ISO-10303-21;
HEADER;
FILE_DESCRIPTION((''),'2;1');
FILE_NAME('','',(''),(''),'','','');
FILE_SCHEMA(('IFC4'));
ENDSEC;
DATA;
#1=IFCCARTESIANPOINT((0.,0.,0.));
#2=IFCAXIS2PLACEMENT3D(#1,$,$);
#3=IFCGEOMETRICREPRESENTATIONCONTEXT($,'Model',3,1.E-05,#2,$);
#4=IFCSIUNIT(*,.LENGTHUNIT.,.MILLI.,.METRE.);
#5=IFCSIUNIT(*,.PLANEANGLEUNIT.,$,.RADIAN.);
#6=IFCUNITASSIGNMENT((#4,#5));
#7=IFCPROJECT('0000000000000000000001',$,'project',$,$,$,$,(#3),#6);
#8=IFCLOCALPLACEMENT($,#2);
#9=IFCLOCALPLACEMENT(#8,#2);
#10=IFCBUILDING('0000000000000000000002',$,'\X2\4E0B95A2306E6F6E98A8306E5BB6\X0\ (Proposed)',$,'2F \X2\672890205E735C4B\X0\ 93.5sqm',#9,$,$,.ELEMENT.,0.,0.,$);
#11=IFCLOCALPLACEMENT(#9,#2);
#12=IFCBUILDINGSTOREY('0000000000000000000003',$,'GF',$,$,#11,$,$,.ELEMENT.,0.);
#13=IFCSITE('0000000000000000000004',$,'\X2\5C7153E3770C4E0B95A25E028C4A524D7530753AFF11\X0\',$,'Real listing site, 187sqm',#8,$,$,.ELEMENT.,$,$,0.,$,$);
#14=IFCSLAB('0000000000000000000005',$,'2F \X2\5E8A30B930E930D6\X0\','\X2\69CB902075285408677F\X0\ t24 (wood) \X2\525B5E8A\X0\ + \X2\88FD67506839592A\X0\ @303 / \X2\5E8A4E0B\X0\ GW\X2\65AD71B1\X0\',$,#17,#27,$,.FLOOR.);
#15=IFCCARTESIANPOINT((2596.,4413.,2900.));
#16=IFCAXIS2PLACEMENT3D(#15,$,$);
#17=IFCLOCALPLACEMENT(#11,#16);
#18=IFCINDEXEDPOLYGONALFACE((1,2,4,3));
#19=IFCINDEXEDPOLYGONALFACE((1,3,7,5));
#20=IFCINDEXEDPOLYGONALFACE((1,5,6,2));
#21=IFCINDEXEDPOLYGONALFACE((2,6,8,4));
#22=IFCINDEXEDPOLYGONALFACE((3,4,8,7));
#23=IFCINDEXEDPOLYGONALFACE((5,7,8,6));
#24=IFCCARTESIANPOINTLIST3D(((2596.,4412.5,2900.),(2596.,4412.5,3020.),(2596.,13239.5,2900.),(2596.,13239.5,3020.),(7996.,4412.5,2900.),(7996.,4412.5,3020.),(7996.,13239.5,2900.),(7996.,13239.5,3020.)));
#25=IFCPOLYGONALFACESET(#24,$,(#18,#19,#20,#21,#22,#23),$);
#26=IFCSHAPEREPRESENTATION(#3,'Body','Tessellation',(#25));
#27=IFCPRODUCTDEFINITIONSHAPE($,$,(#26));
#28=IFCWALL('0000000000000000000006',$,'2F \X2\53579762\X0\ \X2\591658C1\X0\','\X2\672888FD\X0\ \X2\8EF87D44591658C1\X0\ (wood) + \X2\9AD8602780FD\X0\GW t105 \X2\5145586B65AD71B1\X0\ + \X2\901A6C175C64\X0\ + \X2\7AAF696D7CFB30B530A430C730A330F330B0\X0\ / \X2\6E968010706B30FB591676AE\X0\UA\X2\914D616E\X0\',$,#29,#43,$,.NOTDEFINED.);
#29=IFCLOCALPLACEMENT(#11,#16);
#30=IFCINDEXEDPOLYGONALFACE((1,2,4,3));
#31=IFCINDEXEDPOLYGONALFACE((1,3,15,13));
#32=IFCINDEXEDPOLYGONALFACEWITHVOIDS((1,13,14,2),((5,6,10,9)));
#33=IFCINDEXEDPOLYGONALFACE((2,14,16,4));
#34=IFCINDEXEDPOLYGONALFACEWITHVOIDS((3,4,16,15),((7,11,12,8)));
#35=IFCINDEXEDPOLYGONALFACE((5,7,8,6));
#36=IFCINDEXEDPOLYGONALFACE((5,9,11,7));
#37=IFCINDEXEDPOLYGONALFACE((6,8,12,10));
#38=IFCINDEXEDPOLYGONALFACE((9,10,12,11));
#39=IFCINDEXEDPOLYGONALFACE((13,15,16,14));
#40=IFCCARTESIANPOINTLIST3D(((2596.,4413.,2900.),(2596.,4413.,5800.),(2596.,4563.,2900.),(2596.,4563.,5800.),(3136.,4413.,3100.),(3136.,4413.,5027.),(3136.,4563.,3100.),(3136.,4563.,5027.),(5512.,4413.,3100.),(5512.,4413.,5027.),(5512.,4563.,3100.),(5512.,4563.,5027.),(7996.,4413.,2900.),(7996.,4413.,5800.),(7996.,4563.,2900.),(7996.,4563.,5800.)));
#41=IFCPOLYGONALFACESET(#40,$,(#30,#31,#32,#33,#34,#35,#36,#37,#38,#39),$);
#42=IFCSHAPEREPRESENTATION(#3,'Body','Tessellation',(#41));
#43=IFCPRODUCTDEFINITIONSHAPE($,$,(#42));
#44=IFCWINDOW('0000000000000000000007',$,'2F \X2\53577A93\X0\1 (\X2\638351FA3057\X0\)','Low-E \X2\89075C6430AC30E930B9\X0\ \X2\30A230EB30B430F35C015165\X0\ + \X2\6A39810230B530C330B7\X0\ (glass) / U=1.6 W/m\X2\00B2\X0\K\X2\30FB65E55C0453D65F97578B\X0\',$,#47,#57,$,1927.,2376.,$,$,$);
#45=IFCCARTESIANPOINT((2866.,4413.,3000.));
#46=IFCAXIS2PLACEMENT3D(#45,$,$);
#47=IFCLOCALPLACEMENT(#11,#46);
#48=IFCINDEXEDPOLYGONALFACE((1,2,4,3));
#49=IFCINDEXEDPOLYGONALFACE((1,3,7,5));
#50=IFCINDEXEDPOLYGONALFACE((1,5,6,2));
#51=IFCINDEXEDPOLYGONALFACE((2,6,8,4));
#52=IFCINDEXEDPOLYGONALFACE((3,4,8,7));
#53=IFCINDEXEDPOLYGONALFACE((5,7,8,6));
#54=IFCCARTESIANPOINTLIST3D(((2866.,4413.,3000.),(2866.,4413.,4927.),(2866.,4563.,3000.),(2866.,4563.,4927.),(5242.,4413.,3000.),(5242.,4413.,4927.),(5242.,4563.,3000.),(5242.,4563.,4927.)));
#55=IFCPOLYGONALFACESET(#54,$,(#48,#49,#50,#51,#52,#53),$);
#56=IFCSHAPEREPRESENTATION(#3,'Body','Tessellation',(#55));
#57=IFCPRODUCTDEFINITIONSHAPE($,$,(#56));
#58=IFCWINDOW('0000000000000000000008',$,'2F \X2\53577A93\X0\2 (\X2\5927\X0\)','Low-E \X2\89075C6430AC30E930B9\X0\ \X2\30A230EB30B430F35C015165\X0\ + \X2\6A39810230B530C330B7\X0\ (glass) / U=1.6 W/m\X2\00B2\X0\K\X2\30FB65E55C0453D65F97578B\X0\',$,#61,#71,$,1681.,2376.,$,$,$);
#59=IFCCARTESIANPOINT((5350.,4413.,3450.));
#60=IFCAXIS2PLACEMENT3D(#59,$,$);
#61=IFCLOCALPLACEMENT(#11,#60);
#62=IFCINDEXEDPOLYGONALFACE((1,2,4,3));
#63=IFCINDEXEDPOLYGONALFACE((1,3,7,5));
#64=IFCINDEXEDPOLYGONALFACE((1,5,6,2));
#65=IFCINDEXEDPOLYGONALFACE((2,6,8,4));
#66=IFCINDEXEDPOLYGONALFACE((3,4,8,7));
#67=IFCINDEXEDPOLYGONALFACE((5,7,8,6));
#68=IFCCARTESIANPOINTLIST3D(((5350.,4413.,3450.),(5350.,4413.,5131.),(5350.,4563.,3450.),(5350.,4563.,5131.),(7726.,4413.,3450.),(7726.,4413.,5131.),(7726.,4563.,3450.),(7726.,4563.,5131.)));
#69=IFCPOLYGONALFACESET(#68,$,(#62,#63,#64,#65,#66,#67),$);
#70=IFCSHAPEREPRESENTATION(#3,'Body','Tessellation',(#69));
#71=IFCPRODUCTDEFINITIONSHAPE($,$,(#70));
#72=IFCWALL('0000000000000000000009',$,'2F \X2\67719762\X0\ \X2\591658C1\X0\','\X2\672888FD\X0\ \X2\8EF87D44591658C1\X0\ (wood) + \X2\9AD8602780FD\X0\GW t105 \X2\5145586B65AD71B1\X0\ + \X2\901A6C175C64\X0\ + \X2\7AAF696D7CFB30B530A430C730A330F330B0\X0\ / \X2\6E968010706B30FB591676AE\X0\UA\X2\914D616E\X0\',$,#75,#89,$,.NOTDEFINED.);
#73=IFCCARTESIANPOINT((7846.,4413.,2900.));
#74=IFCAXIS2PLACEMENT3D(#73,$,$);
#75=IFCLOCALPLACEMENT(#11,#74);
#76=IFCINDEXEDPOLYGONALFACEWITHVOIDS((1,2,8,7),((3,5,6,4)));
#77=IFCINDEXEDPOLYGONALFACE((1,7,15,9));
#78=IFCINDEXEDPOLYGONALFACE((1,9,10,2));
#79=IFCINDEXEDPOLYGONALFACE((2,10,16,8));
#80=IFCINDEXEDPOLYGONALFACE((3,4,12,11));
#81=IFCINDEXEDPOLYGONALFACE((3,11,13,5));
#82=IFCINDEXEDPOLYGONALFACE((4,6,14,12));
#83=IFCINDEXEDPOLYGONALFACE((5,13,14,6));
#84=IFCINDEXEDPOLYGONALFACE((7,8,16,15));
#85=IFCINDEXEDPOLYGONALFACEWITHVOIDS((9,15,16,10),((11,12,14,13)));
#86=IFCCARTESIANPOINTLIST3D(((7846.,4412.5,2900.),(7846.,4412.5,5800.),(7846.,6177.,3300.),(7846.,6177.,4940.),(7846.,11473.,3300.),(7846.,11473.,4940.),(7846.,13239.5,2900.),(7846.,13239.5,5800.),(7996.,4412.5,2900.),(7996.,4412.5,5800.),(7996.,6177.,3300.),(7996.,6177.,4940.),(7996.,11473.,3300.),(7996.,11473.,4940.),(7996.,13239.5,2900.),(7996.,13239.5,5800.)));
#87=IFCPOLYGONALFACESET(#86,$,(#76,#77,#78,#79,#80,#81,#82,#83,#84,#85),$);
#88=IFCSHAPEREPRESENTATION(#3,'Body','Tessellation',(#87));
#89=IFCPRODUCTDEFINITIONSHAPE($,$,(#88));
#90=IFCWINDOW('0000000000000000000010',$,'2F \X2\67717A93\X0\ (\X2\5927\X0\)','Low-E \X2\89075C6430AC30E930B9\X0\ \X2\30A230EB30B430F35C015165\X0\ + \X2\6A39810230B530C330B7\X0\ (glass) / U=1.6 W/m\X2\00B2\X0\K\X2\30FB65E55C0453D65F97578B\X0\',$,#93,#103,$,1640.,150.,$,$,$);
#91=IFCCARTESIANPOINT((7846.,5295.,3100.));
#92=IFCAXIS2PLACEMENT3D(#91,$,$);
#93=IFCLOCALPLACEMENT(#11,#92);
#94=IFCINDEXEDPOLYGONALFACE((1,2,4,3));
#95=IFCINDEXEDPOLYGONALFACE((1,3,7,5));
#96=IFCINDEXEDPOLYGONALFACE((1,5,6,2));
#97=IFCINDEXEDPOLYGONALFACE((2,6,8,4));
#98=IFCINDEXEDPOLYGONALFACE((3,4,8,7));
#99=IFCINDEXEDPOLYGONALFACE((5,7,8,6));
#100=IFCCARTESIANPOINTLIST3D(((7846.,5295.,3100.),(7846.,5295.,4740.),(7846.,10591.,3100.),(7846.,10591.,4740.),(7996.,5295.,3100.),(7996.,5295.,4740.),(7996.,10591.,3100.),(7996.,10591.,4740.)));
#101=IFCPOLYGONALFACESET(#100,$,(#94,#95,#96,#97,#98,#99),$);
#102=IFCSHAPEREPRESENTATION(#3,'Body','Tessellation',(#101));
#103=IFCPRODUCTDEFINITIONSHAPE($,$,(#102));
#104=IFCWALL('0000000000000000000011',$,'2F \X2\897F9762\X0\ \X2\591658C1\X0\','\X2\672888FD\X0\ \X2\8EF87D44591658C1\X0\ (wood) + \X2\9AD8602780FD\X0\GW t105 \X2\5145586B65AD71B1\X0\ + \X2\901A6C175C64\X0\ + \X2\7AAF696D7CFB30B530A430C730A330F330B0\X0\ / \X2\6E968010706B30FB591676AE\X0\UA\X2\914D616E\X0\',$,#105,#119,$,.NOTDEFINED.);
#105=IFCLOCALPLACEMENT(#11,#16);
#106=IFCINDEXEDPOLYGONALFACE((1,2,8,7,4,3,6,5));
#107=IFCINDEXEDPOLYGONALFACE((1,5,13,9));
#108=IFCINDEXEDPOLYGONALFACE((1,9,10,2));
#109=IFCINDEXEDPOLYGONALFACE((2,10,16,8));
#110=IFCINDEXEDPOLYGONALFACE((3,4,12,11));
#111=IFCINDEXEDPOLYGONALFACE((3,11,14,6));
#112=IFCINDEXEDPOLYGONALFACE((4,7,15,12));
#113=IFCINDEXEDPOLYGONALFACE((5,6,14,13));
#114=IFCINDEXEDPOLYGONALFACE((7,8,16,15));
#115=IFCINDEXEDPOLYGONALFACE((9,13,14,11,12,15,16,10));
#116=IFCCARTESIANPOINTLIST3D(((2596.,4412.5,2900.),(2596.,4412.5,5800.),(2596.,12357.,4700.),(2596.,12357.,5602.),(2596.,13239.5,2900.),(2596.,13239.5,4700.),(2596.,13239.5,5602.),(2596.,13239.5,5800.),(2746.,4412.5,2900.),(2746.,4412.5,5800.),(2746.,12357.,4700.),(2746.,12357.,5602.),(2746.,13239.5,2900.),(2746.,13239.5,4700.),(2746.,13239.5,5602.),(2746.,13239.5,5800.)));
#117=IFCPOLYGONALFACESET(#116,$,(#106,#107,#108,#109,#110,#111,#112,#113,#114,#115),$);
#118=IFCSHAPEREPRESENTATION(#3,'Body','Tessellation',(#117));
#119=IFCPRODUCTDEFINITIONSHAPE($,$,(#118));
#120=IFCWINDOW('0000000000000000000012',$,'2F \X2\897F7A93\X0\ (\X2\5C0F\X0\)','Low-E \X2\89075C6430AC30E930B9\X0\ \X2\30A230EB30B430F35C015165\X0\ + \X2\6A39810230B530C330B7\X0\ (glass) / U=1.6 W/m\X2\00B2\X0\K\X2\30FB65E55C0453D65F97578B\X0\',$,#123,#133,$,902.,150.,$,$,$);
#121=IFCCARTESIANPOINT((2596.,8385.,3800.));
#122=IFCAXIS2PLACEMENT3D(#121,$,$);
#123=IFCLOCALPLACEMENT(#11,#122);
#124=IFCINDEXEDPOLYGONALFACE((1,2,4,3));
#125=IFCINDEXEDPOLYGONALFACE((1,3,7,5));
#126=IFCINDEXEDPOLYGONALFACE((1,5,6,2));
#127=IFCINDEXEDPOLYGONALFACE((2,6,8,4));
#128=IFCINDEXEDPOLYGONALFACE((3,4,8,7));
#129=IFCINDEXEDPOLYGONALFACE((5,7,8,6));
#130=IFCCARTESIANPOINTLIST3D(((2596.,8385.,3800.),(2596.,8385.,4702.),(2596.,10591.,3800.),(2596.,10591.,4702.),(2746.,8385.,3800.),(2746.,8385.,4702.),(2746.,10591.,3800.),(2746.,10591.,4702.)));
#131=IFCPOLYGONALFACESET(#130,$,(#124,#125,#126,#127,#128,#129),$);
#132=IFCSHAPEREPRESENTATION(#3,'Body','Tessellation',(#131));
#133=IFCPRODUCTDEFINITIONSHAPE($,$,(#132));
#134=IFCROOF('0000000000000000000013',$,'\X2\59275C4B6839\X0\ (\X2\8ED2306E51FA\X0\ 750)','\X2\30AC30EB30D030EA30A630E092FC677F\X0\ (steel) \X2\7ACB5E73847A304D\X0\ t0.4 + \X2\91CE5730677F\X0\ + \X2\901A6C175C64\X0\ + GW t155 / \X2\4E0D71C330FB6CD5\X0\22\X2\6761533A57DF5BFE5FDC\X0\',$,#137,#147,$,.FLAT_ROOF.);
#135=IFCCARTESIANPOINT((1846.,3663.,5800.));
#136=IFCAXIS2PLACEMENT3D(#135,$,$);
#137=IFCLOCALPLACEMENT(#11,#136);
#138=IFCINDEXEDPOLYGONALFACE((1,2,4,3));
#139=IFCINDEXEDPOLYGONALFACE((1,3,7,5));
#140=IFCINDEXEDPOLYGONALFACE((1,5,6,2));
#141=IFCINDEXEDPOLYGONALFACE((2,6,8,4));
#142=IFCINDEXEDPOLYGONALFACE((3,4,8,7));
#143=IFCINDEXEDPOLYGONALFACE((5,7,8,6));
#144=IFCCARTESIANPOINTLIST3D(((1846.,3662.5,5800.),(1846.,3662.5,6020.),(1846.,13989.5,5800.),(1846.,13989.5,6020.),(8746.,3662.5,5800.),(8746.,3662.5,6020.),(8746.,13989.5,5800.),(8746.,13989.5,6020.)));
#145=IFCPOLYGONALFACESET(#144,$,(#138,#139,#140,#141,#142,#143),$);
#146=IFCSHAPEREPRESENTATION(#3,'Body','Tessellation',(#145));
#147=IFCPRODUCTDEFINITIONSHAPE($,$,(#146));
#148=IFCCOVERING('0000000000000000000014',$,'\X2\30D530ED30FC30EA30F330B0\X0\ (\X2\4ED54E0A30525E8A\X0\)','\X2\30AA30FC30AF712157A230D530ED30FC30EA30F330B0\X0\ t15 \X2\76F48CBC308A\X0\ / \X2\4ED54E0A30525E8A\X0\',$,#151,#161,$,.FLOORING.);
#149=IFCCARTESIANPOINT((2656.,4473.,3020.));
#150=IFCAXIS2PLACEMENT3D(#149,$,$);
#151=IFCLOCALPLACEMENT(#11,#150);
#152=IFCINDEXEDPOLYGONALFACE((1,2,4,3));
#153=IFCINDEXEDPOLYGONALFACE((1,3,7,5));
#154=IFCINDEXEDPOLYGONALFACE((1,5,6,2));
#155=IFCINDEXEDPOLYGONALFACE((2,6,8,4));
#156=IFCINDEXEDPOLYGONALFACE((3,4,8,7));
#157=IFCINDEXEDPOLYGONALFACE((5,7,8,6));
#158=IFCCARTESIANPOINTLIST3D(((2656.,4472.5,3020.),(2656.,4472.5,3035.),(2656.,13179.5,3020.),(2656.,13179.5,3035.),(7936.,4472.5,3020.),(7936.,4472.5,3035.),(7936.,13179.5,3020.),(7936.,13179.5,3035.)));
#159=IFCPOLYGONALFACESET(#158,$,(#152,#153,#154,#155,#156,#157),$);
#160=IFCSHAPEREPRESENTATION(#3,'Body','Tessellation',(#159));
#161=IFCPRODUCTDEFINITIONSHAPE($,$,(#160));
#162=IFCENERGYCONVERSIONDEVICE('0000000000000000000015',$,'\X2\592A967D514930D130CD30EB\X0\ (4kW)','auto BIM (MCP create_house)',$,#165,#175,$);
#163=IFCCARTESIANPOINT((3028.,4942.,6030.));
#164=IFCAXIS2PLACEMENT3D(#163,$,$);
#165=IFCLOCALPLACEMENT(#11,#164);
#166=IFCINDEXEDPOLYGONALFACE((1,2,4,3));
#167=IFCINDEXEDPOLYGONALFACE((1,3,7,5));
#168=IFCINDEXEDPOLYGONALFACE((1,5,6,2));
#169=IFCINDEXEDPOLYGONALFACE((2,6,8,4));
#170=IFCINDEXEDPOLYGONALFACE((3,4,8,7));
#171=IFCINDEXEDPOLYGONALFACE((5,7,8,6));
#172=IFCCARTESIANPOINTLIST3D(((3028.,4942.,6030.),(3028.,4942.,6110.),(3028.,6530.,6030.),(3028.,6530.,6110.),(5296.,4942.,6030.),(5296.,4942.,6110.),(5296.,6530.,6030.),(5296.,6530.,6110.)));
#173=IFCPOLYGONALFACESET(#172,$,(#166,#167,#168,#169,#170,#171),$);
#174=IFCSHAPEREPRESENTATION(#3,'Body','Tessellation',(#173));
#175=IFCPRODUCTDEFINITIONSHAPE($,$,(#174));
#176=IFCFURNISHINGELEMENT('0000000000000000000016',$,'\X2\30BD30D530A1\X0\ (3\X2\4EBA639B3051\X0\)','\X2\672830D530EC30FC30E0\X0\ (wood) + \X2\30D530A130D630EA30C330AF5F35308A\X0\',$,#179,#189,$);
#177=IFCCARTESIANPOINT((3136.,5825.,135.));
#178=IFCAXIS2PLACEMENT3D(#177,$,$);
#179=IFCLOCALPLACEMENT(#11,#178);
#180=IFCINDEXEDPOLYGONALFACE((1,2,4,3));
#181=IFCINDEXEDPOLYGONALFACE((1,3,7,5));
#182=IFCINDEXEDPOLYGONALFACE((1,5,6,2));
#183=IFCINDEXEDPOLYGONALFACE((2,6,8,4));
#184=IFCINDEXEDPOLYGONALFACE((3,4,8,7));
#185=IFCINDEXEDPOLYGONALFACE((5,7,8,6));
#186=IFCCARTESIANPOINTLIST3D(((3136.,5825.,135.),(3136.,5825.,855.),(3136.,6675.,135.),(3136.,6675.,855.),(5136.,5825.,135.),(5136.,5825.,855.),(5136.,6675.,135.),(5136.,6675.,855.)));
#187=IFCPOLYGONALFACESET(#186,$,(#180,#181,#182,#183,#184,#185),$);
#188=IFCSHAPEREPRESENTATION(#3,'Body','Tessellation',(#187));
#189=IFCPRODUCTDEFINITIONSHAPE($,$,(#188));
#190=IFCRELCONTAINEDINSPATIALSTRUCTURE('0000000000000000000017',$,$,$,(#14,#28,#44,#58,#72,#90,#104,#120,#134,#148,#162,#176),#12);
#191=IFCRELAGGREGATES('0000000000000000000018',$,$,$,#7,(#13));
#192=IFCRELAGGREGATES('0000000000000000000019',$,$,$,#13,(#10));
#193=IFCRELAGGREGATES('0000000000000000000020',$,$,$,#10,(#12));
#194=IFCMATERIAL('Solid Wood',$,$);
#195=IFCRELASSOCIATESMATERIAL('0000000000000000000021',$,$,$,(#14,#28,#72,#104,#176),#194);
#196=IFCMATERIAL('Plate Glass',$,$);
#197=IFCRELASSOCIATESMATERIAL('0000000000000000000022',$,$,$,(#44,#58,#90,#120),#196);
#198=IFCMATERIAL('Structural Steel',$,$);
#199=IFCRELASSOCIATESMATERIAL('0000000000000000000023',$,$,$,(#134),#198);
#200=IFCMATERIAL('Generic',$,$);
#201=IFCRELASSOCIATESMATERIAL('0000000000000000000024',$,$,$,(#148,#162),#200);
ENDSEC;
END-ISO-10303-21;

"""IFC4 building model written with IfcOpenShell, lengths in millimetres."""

from ifc_helpers import new_model, si_unit, frame, frame_2d, origin, place, context, project, spatial, rectangle, extrude, material, element, fill, save


model = new_model("IFC4")

# Units and contexts
model_context = context("Model", 3, precision=1e-05, world=origin())
ifc_project = project(units=[si_unit("LENGTHUNIT", "METRE", prefix="MILLI"), si_unit("PLANEANGLEUNIT", "RADIAN")], contexts=[model_context])

# Site, building, storey
site_placement = place(None, origin())
site = spatial("IfcSite", under=ifc_project, at=site_placement, Name="山口県下関市豊前田町１", ObjectType="Real listing site, 187sqm", CompositionType="ELEMENT", RefElevation=0.0)
building_placement = place(site_placement, origin())
building = spatial("IfcBuilding", under=site, at=building_placement, Name="下関の潮風の家 (Proposed)", ObjectType="2F 木造平屋 93.5sqm", CompositionType="ELEMENT", ElevationOfRefHeight=0.0, ElevationOfTerrain=0.0)
storey_placement = place(building_placement, origin())
storey = spatial("IfcBuildingStorey", under=building, at=storey_placement, Name="GF", CompositionType="ELEMENT", Elevation=0.0)

# Slab
ifc_material_1 = material(Name="Solid Wood")
slab_placement = place(storey_placement, frame((2596.0, 4413.0, 2900.0)))
element("IfcSlab", 1, at=slab_placement, inside=storey, material=ifc_material_1, Name="2F 床スラブ", Description="構造用合板 t24 (wood) 剛床 + 製材根太 @303 / 床下 GW断熱", PredefinedType="FLOOR", context=model_context, shape_type="SweptSolid", body=[
    extrude(rectangle(XDim=5400.0, YDim=8827.0, at=frame_2d((2700.0, 4413.0))), frame((2596.0, 4413.0, 2900.0)), (0.0, 0.0, 1.0), 120.0),
])

# Wall, openings, windows
wall_1_placement = place(storey_placement, frame((2596.0, 4413.0, 2900.0)))
wall_1 = element("IfcWall", 2, at=wall_1_placement, inside=storey, material=ifc_material_1, Name="2F 南面 外壁", Description="木製 軸組外壁 (wood) + 高性能GW t105 充填断熱 + 通気層 + 窯業系サイディング / 準耐火・外皮UA配慮", PredefinedType="NOTDEFINED", context=model_context, shape_type="SweptSolid", body=[
    extrude(rectangle(XDim=5400.0, YDim=150.0, at=frame_2d((2700.0, 75.0))), frame((2596.0, 4413.0, 2900.0)), (0.0, 0.0, 1.0), 2900.0),
])
opening_1_placement = place(storey_placement, frame((2866.0, 4413.0, 3000.0)))
opening_1 = element("IfcOpeningElement", 3, at=opening_1_placement, cuts=wall_1, PredefinedType="NOTDEFINED", context=model_context, shape_type="SweptSolid", body=[
    extrude(rectangle(XDim=2376.0, YDim=150.0, at=frame_2d((1188.0, 75.0))), frame((2866.0, 4413.0, 3000.0)), (0.0, 0.0, 1.0), 1927.0),
])
opening_2_placement = place(storey_placement, frame((5350.0, 4413.0, 3450.0)))
opening_2 = element("IfcOpeningElement", 4, at=opening_2_placement, cuts=wall_1, PredefinedType="NOTDEFINED", context=model_context, shape_type="SweptSolid", body=[
    extrude(rectangle(XDim=2376.0, YDim=150.0, at=frame_2d((1188.0, 75.0))), frame((5350.0, 4413.0, 3450.0)), (0.0, 0.0, 1.0), 1681.0),
])
ifc_material_2 = material(Name="Plate Glass")
window_1_placement = place(storey_placement, frame((2866.0, 4413.0, 3000.0)))
window_1 = element("IfcWindow", 5, at=window_1_placement, inside=storey, material=ifc_material_2, Name="2F 南窓1 (掃出し)", Description="Low-E 複層ガラス アルゴン封入 + 樹脂サッシ (glass) / U=1.6 W/m²K・日射取得型", OverallHeight=1927.0, OverallWidth=2376.0, context=model_context, shape_type="SweptSolid", body=[
    extrude(rectangle(XDim=2376.0, YDim=150.0, at=frame_2d((1188.0, 75.0))), frame((2866.0, 4413.0, 3000.0)), (0.0, 0.0, 1.0), 1927.0),
])
fill(opening_1, window_1)
window_2_placement = place(storey_placement, frame((5350.0, 4413.0, 3450.0)))
window_2 = element("IfcWindow", 6, at=window_2_placement, inside=storey, material=ifc_material_2, Name="2F 南窓2 (大)", Description="Low-E 複層ガラス アルゴン封入 + 樹脂サッシ (glass) / U=1.6 W/m²K・日射取得型", OverallHeight=1681.0, OverallWidth=2376.0, context=model_context, shape_type="SweptSolid", body=[
    extrude(rectangle(XDim=2376.0, YDim=150.0, at=frame_2d((1188.0, 75.0))), frame((5350.0, 4413.0, 3450.0)), (0.0, 0.0, 1.0), 1681.0),
])
fill(opening_2, window_2)

# Walls, openings, windows
wall_2_placement = place(storey_placement, frame((7846.0, 4413.0, 2900.0)))
wall_2 = element("IfcWall", 7, at=wall_2_placement, inside=storey, material=ifc_material_1, Name="2F 東面 外壁", Description="木製 軸組外壁 (wood) + 高性能GW t105 充填断熱 + 通気層 + 窯業系サイディング / 準耐火・外皮UA配慮", PredefinedType="NOTDEFINED", context=model_context, shape_type="SweptSolid", body=[
    extrude(rectangle(XDim=150.0, YDim=8827.0, at=frame_2d((75.0, 4413.0))), frame((7846.0, 4413.0, 2900.0)), (0.0, 0.0, 1.0), 2900.0),
])
opening_3_placement = place(storey_placement, frame((7846.0, 5295.0, 3100.0)))
opening_3 = element("IfcOpeningElement", 8, at=opening_3_placement, cuts=wall_2, PredefinedType="NOTDEFINED", context=model_context, shape_type="SweptSolid", body=[
    extrude(rectangle(XDim=150.0, YDim=5296.0, at=frame_2d((75.0, 2648.0))), frame((7846.0, 5295.0, 3100.0)), (0.0, 0.0, 1.0), 1640.0),
])
window_3_placement = place(storey_placement, frame((7846.0, 5295.0, 3100.0)))
window_3 = element("IfcWindow", 9, at=window_3_placement, inside=storey, material=ifc_material_2, Name="2F 東窓 (大)", Description="Low-E 複層ガラス アルゴン封入 + 樹脂サッシ (glass) / U=1.6 W/m²K・日射取得型", OverallHeight=1640.0, OverallWidth=150.0, context=model_context, shape_type="SweptSolid", body=[
    extrude(rectangle(XDim=150.0, YDim=5296.0, at=frame_2d((75.0, 2648.0))), frame((7846.0, 5295.0, 3100.0)), (0.0, 0.0, 1.0), 1640.0),
])
fill(opening_3, window_3)
wall_3_placement = place(storey_placement, frame((2596.0, 4413.0, 2900.0)))
wall_3 = element("IfcWall", 10, at=wall_3_placement, inside=storey, material=ifc_material_1, Name="2F 西面 外壁", Description="木製 軸組外壁 (wood) + 高性能GW t105 充填断熱 + 通気層 + 窯業系サイディング / 準耐火・外皮UA配慮", PredefinedType="NOTDEFINED", context=model_context, shape_type="SweptSolid", body=[
    extrude(rectangle(XDim=150.0, YDim=8827.0, at=frame_2d((75.0, 4413.0))), frame((2596.0, 4413.0, 2900.0)), (0.0, 0.0, 1.0), 2900.0),
])
opening_4_placement = place(storey_placement, frame((2596.0, 8385.0, 3800.0)))
opening_4 = element("IfcOpeningElement", 11, at=opening_4_placement, cuts=wall_3, PredefinedType="NOTDEFINED", context=model_context, shape_type="SweptSolid", body=[
    extrude(rectangle(XDim=150.0, YDim=2206.0, at=frame_2d((75.0, 1103.0))), frame((2596.0, 8385.0, 3800.0)), (0.0, 0.0, 1.0), 902.0),
])
window_4_placement = place(storey_placement, frame((2596.0, 8385.0, 3800.0)))
window_4 = element("IfcWindow", 12, at=window_4_placement, inside=storey, material=ifc_material_2, Name="2F 西窓 (小)", Description="Low-E 複層ガラス アルゴン封入 + 樹脂サッシ (glass) / U=1.6 W/m²K・日射取得型", OverallHeight=902.0, OverallWidth=150.0, context=model_context, shape_type="SweptSolid", body=[
    extrude(rectangle(XDim=150.0, YDim=2206.0, at=frame_2d((75.0, 1103.0))), frame((2596.0, 8385.0, 3800.0)), (0.0, 0.0, 1.0), 902.0),
])
fill(opening_4, window_4)

# Roof
ifc_material_3 = material(Name="Structural Steel")
roof_placement = place(storey_placement, frame((1846.0, 3663.0, 5800.0)))
element("IfcRoof", 13, at=roof_placement, inside=storey, material=ifc_material_3, Name="大屋根 (軒の出 750)", Description="ガルバリウム鋼板 (steel) 立平葺き t0.4 + 野地板 + 通気層 + GW t155 / 不燃・法22条区域対応", PredefinedType="FLAT_ROOF", context=model_context, shape_type="SweptSolid", body=[
    extrude(rectangle(XDim=6900.0, YDim=10327.0, at=frame_2d((3450.0, 5163.0))), frame((1846.0, 3663.0, 5800.0)), (0.0, 0.0, 1.0), 220.0),
])

# Covering
ifc_material_4 = material(Name="Generic")
covering_placement = place(storey_placement, frame((2656.0, 4473.0, 3020.0)))
element("IfcCovering", 14, at=covering_placement, inside=storey, material=ifc_material_4, Name="フローリング (仕上げ床)", Description="オーク無垢フローリング t15 直貼り / 仕上げ床", PredefinedType="FLOORING", context=model_context, shape_type="SweptSolid", body=[
    extrude(rectangle(XDim=5280.0, YDim=8707.0, at=frame_2d((2640.0, 4353.0))), frame((2656.0, 4473.0, 3020.0)), (0.0, 0.0, 1.0), 15.0),
])

# Energy conversion device
energy_conversion_device_placement = place(storey_placement, frame((3028.0, 4942.0, 6030.0)))
element("IfcEnergyConversionDevice", 15, at=energy_conversion_device_placement, inside=storey, material=ifc_material_4, Name="太陽光パネル (4kW)", Description="auto BIM (MCP create_house)", context=model_context, shape_type="SweptSolid", body=[
    extrude(rectangle(XDim=2268.0, YDim=1588.0, at=frame_2d((1134.0, 794.0))), frame((3028.0, 4942.0, 6030.0)), (0.0, 0.0, 1.0), 80.0),
])

# Furnishing element
furnishing_1_placement = place(storey_placement, frame((3136.0, 5825.0, 135.0)))
element("IfcFurnishingElement", 16, at=furnishing_1_placement, inside=storey, material=ifc_material_1, Name="ソファ (3人掛け)", Description="木フレーム (wood) + ファブリック張り", context=model_context, shape_type="SweptSolid", body=[
    extrude(rectangle(XDim=2000.0, YDim=850.0, at=frame_2d((1000.0, 425.0))), frame((3136.0, 5825.0, 135.0)), (0.0, 0.0, 1.0), 720.0),
])

save(model, "model.ifc")
